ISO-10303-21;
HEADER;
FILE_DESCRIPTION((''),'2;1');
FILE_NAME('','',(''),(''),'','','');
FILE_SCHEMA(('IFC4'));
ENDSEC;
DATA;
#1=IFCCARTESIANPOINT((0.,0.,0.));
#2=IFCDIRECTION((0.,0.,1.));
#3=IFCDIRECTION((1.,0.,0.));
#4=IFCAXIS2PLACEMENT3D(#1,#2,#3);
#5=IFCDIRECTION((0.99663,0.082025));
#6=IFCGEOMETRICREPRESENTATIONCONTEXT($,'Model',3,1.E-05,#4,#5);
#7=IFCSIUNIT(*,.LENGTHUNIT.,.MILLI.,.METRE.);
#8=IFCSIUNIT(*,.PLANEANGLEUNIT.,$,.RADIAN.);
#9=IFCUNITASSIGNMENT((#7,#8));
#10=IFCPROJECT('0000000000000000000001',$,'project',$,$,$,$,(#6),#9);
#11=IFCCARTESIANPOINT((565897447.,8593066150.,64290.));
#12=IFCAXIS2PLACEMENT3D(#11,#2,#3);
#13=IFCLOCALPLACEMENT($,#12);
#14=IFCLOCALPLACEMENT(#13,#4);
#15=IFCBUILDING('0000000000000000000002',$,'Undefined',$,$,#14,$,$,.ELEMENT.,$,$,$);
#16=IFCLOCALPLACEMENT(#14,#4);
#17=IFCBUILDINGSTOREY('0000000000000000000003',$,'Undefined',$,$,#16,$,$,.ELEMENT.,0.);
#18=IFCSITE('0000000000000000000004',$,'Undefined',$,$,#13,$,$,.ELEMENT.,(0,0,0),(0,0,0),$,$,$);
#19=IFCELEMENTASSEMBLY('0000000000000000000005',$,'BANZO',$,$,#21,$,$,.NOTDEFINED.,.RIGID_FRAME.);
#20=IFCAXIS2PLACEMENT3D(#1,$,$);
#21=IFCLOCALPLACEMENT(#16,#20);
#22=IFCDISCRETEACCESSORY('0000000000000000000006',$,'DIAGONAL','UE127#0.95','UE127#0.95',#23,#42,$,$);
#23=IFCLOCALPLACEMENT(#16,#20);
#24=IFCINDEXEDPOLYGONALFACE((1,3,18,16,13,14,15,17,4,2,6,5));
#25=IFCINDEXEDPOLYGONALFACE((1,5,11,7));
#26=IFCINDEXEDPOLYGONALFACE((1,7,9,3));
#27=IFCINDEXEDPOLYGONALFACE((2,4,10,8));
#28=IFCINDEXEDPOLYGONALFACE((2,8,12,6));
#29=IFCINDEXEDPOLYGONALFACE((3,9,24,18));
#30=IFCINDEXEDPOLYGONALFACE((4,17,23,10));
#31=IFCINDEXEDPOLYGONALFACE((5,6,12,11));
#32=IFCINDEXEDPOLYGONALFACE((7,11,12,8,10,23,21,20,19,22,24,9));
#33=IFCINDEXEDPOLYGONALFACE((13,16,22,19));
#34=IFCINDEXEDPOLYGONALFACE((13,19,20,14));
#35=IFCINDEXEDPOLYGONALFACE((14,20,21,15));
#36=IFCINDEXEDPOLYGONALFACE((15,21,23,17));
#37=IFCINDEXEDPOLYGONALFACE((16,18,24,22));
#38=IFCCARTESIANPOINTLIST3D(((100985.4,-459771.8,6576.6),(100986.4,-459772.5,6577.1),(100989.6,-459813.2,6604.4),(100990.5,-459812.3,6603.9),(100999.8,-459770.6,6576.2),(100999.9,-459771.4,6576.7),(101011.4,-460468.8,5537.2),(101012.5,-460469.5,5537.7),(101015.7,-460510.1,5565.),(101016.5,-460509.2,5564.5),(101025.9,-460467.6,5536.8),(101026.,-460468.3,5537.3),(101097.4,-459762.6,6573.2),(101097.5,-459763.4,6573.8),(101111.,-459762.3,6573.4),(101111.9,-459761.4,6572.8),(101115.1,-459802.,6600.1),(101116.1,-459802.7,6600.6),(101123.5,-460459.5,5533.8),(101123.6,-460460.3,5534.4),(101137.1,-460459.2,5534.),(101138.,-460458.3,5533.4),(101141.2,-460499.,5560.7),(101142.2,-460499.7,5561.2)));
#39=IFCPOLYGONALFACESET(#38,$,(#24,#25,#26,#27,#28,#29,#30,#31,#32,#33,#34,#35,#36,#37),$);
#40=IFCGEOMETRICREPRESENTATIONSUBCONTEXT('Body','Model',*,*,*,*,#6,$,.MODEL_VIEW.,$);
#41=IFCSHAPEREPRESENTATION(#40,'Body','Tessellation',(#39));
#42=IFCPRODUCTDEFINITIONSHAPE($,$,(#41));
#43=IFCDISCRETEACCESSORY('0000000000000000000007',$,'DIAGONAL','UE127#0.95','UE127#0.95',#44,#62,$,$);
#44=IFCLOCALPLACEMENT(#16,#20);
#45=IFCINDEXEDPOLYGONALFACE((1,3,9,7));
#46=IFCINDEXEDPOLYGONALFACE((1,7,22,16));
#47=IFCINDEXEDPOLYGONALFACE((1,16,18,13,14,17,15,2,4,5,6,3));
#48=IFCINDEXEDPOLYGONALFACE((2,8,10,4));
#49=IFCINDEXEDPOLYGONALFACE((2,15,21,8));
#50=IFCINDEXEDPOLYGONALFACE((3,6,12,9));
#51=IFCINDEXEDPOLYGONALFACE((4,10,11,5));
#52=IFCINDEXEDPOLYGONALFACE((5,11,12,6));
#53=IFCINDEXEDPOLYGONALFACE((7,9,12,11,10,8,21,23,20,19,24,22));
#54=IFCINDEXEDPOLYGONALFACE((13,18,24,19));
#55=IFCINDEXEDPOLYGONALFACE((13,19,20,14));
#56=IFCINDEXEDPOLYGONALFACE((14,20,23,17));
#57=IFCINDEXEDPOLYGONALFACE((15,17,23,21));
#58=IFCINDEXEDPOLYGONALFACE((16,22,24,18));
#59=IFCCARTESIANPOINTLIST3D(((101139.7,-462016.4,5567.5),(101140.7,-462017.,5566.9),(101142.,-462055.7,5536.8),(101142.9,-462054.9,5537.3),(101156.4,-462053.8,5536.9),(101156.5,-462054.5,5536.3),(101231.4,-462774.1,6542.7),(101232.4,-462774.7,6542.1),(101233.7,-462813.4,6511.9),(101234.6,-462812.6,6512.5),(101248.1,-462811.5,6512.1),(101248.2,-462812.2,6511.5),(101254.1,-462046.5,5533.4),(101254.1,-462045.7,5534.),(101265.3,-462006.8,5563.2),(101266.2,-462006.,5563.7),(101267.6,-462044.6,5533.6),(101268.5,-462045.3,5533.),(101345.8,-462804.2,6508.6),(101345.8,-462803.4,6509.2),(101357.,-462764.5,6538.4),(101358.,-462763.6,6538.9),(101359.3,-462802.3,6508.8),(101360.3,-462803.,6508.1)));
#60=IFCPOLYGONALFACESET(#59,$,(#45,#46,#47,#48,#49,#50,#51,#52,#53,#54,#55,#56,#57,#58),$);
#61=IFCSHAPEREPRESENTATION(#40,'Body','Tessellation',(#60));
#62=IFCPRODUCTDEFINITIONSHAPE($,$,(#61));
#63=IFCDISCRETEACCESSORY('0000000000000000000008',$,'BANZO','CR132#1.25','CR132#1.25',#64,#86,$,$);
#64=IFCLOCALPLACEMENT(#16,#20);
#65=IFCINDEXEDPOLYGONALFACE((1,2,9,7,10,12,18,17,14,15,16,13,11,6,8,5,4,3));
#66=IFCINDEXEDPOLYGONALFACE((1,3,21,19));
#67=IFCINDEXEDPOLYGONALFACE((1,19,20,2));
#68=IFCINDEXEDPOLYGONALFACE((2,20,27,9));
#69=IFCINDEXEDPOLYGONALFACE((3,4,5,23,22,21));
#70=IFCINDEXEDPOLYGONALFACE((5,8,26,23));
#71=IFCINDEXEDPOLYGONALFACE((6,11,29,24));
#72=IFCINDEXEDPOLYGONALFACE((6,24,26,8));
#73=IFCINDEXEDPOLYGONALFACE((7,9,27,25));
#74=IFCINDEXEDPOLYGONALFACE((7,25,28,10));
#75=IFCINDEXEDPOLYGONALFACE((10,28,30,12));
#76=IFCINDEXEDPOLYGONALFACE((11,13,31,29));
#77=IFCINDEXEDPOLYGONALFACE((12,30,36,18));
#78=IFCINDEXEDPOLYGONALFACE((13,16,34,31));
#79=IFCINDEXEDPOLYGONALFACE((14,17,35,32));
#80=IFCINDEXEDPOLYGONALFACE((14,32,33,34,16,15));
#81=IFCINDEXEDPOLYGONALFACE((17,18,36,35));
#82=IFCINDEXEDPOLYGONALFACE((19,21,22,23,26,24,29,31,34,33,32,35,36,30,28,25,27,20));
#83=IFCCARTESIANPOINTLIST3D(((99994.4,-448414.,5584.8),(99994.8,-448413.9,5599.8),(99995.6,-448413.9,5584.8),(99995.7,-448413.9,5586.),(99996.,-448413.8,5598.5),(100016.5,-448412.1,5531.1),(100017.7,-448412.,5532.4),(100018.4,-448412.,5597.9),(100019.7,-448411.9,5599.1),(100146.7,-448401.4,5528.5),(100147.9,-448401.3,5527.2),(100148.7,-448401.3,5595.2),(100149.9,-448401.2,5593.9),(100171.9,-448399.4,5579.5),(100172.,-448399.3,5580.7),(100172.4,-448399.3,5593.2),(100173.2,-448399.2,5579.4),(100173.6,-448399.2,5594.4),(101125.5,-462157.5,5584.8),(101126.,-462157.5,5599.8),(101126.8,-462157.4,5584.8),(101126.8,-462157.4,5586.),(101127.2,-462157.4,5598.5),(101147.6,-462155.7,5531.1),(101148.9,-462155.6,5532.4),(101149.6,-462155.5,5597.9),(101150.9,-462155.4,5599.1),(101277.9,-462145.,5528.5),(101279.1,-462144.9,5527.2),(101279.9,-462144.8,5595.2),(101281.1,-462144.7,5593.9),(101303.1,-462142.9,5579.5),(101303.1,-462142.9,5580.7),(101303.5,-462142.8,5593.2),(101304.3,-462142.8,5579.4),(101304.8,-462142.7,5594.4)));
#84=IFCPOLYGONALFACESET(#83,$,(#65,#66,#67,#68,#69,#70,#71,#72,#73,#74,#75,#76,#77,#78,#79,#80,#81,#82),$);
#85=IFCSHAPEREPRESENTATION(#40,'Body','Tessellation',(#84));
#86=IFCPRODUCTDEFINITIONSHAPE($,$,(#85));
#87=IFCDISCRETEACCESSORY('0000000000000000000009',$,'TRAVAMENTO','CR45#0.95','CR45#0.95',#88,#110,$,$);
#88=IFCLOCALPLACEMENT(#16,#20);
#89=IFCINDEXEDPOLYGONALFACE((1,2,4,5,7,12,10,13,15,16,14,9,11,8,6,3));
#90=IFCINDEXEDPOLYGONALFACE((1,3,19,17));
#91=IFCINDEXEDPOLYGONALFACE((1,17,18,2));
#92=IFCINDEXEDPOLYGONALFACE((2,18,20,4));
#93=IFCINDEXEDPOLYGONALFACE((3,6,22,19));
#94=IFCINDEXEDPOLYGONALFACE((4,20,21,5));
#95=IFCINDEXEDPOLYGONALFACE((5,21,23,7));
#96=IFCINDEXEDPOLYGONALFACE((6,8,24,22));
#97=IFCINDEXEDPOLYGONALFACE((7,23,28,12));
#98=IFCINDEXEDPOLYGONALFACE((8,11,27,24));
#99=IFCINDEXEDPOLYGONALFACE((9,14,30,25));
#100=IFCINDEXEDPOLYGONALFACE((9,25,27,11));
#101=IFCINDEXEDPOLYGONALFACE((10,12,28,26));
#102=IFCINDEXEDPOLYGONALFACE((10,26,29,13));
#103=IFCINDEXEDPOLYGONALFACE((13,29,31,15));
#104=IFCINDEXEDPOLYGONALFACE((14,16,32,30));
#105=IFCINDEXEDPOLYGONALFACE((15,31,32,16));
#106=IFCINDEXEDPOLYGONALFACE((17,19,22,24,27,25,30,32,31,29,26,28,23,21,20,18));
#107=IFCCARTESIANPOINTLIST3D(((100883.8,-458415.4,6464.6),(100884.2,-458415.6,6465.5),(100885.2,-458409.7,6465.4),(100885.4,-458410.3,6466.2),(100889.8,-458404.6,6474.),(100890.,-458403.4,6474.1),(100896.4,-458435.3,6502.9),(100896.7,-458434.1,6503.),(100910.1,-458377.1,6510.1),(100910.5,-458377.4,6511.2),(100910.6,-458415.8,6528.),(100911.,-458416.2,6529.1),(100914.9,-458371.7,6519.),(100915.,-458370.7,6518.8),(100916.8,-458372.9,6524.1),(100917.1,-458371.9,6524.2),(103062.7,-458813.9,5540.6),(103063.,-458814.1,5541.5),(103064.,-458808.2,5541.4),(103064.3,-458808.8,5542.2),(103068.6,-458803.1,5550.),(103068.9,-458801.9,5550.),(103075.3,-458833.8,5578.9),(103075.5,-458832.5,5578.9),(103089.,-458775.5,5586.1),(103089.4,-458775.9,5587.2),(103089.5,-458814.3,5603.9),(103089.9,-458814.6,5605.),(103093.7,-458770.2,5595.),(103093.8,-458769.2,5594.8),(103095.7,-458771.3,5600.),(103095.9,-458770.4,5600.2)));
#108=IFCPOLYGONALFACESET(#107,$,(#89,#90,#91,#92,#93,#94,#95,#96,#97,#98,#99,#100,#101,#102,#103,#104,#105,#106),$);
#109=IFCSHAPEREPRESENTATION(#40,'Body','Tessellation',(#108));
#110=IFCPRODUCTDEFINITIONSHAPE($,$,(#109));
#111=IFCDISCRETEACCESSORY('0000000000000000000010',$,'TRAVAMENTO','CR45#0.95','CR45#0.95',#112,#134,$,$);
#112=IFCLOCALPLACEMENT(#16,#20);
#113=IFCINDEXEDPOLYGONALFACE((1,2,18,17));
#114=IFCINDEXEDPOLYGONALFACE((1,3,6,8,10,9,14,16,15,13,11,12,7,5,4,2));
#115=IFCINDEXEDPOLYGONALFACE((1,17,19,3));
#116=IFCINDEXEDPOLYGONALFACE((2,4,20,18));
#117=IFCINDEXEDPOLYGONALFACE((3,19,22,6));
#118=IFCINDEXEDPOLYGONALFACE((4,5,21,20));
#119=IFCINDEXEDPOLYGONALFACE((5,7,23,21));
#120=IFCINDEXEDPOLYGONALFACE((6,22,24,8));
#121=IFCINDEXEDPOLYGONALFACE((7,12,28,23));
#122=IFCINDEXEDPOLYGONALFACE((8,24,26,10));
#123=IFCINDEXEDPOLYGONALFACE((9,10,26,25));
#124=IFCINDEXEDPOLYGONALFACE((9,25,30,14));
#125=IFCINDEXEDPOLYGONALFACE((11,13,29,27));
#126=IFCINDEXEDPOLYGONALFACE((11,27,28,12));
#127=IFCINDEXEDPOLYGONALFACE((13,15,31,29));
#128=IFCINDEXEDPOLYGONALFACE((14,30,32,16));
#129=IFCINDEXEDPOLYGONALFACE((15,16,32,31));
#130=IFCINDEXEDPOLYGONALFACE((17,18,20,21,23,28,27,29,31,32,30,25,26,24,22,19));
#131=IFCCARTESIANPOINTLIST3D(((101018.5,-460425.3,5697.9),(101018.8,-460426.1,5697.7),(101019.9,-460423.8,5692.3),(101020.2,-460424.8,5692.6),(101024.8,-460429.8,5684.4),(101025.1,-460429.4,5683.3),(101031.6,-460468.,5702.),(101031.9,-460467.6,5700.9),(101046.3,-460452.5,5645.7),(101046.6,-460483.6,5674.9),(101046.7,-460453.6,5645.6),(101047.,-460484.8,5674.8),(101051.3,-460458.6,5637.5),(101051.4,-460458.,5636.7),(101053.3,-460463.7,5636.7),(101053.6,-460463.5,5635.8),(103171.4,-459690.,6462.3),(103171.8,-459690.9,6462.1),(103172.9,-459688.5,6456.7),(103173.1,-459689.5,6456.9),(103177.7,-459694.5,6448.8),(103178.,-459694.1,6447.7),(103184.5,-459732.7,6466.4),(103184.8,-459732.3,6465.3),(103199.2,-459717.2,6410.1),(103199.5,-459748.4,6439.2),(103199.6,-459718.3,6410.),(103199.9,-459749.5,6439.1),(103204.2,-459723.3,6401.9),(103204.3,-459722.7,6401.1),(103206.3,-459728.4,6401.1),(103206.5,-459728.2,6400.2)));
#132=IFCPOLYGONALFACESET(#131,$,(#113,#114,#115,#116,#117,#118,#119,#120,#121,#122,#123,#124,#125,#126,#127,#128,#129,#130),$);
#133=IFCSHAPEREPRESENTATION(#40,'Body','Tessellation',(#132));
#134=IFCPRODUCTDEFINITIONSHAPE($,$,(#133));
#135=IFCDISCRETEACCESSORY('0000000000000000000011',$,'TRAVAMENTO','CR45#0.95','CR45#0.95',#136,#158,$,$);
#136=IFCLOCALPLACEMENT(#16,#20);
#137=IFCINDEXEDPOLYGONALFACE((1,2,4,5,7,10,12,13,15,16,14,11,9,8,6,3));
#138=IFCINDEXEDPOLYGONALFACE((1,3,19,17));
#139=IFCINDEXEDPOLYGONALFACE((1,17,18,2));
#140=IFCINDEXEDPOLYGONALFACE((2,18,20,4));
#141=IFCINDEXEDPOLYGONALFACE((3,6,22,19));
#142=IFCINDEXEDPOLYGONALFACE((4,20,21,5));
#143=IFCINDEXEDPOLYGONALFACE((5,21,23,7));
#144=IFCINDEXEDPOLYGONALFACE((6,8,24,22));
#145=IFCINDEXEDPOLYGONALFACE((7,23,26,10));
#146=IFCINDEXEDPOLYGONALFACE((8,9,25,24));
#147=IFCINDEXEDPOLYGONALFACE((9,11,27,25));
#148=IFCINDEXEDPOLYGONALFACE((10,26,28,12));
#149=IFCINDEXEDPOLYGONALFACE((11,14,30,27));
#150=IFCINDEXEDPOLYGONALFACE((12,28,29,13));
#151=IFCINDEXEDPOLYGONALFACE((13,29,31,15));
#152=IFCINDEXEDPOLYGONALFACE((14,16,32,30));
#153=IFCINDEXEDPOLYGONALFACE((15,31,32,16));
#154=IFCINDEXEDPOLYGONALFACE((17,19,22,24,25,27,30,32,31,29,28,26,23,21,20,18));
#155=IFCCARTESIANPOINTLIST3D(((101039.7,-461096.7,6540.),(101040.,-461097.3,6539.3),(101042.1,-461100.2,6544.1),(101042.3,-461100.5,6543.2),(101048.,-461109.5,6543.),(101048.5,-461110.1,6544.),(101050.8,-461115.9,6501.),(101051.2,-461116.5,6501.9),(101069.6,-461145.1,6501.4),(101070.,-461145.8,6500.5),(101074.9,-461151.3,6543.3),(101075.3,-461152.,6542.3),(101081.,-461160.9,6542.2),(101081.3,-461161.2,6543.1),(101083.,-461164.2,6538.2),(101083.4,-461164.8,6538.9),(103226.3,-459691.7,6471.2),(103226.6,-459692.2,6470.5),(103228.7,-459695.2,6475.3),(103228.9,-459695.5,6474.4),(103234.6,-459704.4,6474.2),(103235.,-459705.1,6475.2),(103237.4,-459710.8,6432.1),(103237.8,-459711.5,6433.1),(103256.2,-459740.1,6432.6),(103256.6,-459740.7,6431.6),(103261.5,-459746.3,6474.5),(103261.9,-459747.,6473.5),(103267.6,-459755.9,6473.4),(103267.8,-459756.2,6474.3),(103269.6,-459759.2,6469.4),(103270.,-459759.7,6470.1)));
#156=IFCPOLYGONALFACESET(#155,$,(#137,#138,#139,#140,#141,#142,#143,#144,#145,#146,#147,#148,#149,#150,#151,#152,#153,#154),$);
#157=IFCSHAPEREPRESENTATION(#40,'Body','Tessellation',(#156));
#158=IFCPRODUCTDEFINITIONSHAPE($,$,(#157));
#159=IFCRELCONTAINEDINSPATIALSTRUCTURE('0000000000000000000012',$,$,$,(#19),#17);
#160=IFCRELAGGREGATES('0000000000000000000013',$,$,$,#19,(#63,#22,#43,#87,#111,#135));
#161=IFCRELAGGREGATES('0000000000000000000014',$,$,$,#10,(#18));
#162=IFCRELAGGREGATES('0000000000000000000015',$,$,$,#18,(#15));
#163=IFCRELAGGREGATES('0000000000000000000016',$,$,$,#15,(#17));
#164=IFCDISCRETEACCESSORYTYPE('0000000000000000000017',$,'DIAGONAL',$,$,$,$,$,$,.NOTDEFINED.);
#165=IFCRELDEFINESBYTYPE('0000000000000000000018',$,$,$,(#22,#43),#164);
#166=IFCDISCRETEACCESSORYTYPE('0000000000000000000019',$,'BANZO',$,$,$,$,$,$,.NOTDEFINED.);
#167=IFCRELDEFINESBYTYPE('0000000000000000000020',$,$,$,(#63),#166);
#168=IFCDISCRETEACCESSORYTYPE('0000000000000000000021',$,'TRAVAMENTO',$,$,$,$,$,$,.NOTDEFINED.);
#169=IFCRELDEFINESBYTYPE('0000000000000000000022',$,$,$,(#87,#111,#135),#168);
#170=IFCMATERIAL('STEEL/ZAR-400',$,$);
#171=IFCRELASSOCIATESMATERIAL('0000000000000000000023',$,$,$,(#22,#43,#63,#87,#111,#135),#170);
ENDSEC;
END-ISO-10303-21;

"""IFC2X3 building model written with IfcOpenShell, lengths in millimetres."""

from ifc_helpers import new_model, si_unit, direction, frame, frame_2d, origin_with_axes, place, context, subcontext, project, spatial, polyline, c_section, outline, extrude, material, type_object, element, aggregate, save


model = new_model("IFC2X3")

# Units and contexts
model_context = context("Model", 3, precision=1e-05, world=origin_with_axes(), true_north=direction((0.99663, 0.082025)))
body_context = subcontext(model_context, "Body", "Model", "MODEL_VIEW")
ifc_project = project(units=[si_unit("LENGTHUNIT", "METRE", prefix="MILLI"), si_unit("PLANEANGLEUNIT", "RADIAN")], contexts=[model_context])

# Site, building, storey
site_placement = place(None, frame((565897447.0, 8593066150.0, 64290.0), z_axis=(0.0, 0.0, 1.0), x_axis=(1.0, 0.0, 0.0)))
site = spatial("IfcSite", under=ifc_project, at=site_placement, Name="Undefined", CompositionType="ELEMENT", RefLatitude=(0, 0, 0), RefLongitude=(0, 0, 0))
building_placement = place(site_placement, origin_with_axes())
building = spatial("IfcBuilding", under=site, at=building_placement, Name="Undefined", CompositionType="ELEMENT")
storey_placement = place(building_placement, origin_with_axes())
storey = spatial("IfcBuildingStorey", under=building, at=storey_placement, Name="Undefined", CompositionType="ELEMENT", Elevation=0.0)

# Shared definitions
ifc_material_1 = material(Name="STEEL/ZAR-400")

# Element assembly, discrete accessories
assembly_1_placement = place(storey_placement, origin_with_axes())
assembly_1 = element("IfcElementAssembly", 1, at=assembly_1_placement, inside=storey, Name="BANZO", AssemblyPlace="NOTDEFINED", PredefinedType="RIGID_FRAME")
discrete_accessory_type_1 = type_object("IfcDiscreteAccessoryType", Name="DIAGONAL")
discrete_accessory_1_placement = place(assembly_1_placement, frame((101050.7, -459787.3, 6588.6), z_axis=(-0.996182, -0.081989, 0.029987), x_axis=(0.020829, -0.556784, -0.830396)))
discrete_accessory_1 = element("IfcDiscreteAccessory", 2, at=discrete_accessory_1_placement, type_object=discrete_accessory_type_1, material=ifc_material_1, Name="DIAGONAL", Description="UE127#0.95", ObjectType="UE127#0.95", context=body_context, shape_type="SweptSolid", body=[
    extrude(c_section(Depth=127.0, Width=50.0, WallThickness=0.9, Girth=14.5, at=frame_2d((0.0, 0.0), x_axis=(1.0, 0.0))), frame((1251.7, 0.0, 0.0), z_axis=(-1.0, 0.0, 0.0), x_axis=(0.0, -1.0, 0.0)), (0.0, 0.0, 1.0), 1251.7),
])
discrete_accessory_2_placement = place(assembly_1_placement, frame((101204.1, -462030.8, 5550.2), z_axis=(-0.996182, -0.081989, 0.029987), x_axis=(0.074062, -0.611853, 0.787496)))
discrete_accessory_2 = element("IfcDiscreteAccessory", 3, at=discrete_accessory_2_placement, type_object=discrete_accessory_type_1, material=ifc_material_1, Name="DIAGONAL", Description="UE127#0.95", ObjectType="UE127#0.95", context=body_context, shape_type="SweptSolid", body=[
    extrude(c_section(Depth=127.0, Width=50.0, WallThickness=0.9, Girth=14.5, at=frame_2d((0.0, 0.0), x_axis=(1.0, 0.0))), frame((1238.3, 0.0, 0.0), z_axis=(-1.0, 0.0, 0.0), x_axis=(0.0, -1.0, 0.0)), (0.0, 0.0, 1.0), 1238.3),
])
discrete_accessory_type_2 = type_object("IfcDiscreteAccessoryType", Name="BANZO")
discrete_accessory_3_placement = place(assembly_1_placement, frame((101214.3, -462150.2, 5563.1), z_axis=(-0.029886, -0.00246, -0.99955), x_axis=(-0.082025, 0.99663, 0.0)))
discrete_accessory_3 = element("IfcDiscreteAccessory", 4, at=discrete_accessory_3_placement, type_object=discrete_accessory_type_2, material=ifc_material_1, Name="BANZO", Description="CR132#1.25", ObjectType="CR132#1.25", context=body_context, shape_type="SweptSolid", body=[
    extrude(outline(polyline([(-64.7, 32.7), (-64.7, -34.0), (-89.7, -34.0), (-89.7, -19.0), (-88.5, -19.0), (-88.5, -20.3), (-88.5, -32.8), (-66.0, -32.8), (-66.0, 34.0), (66.0, 34.0), (66.0, -32.7), (88.5, -32.7), (88.5, -20.2), (88.5, -19.0), (89.7, -19.0), (89.7, -34.0), (64.7, -34.0), (64.7, 32.8), (-64.7, 32.7)])), frame((13790.0, 0.0, 0.0), z_axis=(-1.0, 0.0, 0.0), x_axis=(0.0, -1.0, 0.0)), (0.0, 0.0, 1.0), 13790.0),
])
discrete_accessory_type_3 = type_object("IfcDiscreteAccessoryType", Name="TRAVAMENTO")
discrete_accessory_4_placement = place(assembly_1_placement, frame((103080.6, -458806.6, 5579.8), z_axis=(0.084779, -0.826601, 0.556366), x_axis=(-0.907854, 0.16603, 0.385013)))
discrete_accessory_4 = element("IfcDiscreteAccessory", 5, at=discrete_accessory_4_placement, type_object=discrete_accessory_type_3, material=ifc_material_1, Name="TRAVAMENTO", Description="CR45#0.95", ObjectType="CR45#0.95", context=body_context, shape_type="SweptSolid", body=[
    extrude(outline(polyline([(-35.5, -20.5), (-24.9, -20.5), (-17.4, 21.5), (18.1, 21.5), (25.6, -20.5), (36.2, -20.5), (40.1, -16.6), (40.8, -17.3), (36.6, -21.5), (24.8, -21.5), (17.3, 20.5), (-16.6, 20.5), (-24.1, -21.5), (-35.9, -21.5), (-40.1, -17.3), (-39.4, -16.6), (-35.5, -20.5)])), frame((2400.0, 0.0, 0.0), z_axis=(-1.0, 0.0, 0.0), x_axis=(0.0, -1.0, 0.0)), (0.0, 0.0, 1.0), 2400.0),
])
discrete_accessory_5_placement = place(assembly_1_placement, frame((101037.3, -460458.5, 5676.7), z_axis=(0.084779, -0.826601, 0.556366), x_axis=(0.897052, 0.306371, 0.318488)))
discrete_accessory_5 = element("IfcDiscreteAccessory", 6, at=discrete_accessory_5_placement, type_object=discrete_accessory_type_3, material=ifc_material_1, Name="TRAVAMENTO", Description="CR45#0.95", ObjectType="CR45#0.95", context=body_context, shape_type="SweptSolid", body=[
    extrude(outline(polyline([(-35.5, -20.5), (-24.9, -20.5), (-17.4, 21.5), (18.1, 21.5), (25.6, -20.5), (36.2, -20.5), (40.1, -16.6), (40.8, -17.3), (36.6, -21.5), (24.8, -21.5), (17.3, 20.5), (-16.6, 20.5), (-24.1, -21.5), (-35.9, -21.5), (-40.1, -17.3), (-39.4, -16.6), (-35.5, -20.5)])), frame((2400.0, 0.0, 0.0), z_axis=(-1.0, 0.0, 0.0), x_axis=(0.0, -1.0, 0.0)), (0.0, 0.0, 1.0), 2400.0),
])
discrete_accessory_6_placement = place(assembly_1_placement, frame((101061.2, -461131.0, 6522.2), z_axis=(-0.029884, -0.002459, -0.99955), x_axis=(0.840995, 0.540395, -0.026473)))
discrete_accessory_6 = element("IfcDiscreteAccessory", 7, at=discrete_accessory_6_placement, type_object=discrete_accessory_type_3, material=ifc_material_1, Name="TRAVAMENTO", Description="CR45#0.95", ObjectType="CR45#0.95", context=body_context, shape_type="SweptSolid", body=[
    extrude(outline(polyline([(-35.5, -20.5), (-24.9, -20.5), (-17.4, 21.5), (18.1, 21.5), (25.6, -20.5), (36.2, -20.5), (40.1, -16.6), (40.8, -17.3), (36.6, -21.5), (24.8, -21.5), (17.3, 20.5), (-16.6, 20.5), (-24.1, -21.5), (-35.9, -21.5), (-40.1, -17.3), (-39.4, -16.6), (-35.5, -20.5)])), frame((2600.0, 0.0, 0.0), z_axis=(-1.0, 0.0, 0.0), x_axis=(0.0, -1.0, 0.0)), (0.0, 0.0, 1.0), 2600.0),
])
aggregate(assembly_1, [discrete_accessory_3, discrete_accessory_1, discrete_accessory_2, discrete_accessory_4, discrete_accessory_5, discrete_accessory_6])

save(model, "model.ifc")
